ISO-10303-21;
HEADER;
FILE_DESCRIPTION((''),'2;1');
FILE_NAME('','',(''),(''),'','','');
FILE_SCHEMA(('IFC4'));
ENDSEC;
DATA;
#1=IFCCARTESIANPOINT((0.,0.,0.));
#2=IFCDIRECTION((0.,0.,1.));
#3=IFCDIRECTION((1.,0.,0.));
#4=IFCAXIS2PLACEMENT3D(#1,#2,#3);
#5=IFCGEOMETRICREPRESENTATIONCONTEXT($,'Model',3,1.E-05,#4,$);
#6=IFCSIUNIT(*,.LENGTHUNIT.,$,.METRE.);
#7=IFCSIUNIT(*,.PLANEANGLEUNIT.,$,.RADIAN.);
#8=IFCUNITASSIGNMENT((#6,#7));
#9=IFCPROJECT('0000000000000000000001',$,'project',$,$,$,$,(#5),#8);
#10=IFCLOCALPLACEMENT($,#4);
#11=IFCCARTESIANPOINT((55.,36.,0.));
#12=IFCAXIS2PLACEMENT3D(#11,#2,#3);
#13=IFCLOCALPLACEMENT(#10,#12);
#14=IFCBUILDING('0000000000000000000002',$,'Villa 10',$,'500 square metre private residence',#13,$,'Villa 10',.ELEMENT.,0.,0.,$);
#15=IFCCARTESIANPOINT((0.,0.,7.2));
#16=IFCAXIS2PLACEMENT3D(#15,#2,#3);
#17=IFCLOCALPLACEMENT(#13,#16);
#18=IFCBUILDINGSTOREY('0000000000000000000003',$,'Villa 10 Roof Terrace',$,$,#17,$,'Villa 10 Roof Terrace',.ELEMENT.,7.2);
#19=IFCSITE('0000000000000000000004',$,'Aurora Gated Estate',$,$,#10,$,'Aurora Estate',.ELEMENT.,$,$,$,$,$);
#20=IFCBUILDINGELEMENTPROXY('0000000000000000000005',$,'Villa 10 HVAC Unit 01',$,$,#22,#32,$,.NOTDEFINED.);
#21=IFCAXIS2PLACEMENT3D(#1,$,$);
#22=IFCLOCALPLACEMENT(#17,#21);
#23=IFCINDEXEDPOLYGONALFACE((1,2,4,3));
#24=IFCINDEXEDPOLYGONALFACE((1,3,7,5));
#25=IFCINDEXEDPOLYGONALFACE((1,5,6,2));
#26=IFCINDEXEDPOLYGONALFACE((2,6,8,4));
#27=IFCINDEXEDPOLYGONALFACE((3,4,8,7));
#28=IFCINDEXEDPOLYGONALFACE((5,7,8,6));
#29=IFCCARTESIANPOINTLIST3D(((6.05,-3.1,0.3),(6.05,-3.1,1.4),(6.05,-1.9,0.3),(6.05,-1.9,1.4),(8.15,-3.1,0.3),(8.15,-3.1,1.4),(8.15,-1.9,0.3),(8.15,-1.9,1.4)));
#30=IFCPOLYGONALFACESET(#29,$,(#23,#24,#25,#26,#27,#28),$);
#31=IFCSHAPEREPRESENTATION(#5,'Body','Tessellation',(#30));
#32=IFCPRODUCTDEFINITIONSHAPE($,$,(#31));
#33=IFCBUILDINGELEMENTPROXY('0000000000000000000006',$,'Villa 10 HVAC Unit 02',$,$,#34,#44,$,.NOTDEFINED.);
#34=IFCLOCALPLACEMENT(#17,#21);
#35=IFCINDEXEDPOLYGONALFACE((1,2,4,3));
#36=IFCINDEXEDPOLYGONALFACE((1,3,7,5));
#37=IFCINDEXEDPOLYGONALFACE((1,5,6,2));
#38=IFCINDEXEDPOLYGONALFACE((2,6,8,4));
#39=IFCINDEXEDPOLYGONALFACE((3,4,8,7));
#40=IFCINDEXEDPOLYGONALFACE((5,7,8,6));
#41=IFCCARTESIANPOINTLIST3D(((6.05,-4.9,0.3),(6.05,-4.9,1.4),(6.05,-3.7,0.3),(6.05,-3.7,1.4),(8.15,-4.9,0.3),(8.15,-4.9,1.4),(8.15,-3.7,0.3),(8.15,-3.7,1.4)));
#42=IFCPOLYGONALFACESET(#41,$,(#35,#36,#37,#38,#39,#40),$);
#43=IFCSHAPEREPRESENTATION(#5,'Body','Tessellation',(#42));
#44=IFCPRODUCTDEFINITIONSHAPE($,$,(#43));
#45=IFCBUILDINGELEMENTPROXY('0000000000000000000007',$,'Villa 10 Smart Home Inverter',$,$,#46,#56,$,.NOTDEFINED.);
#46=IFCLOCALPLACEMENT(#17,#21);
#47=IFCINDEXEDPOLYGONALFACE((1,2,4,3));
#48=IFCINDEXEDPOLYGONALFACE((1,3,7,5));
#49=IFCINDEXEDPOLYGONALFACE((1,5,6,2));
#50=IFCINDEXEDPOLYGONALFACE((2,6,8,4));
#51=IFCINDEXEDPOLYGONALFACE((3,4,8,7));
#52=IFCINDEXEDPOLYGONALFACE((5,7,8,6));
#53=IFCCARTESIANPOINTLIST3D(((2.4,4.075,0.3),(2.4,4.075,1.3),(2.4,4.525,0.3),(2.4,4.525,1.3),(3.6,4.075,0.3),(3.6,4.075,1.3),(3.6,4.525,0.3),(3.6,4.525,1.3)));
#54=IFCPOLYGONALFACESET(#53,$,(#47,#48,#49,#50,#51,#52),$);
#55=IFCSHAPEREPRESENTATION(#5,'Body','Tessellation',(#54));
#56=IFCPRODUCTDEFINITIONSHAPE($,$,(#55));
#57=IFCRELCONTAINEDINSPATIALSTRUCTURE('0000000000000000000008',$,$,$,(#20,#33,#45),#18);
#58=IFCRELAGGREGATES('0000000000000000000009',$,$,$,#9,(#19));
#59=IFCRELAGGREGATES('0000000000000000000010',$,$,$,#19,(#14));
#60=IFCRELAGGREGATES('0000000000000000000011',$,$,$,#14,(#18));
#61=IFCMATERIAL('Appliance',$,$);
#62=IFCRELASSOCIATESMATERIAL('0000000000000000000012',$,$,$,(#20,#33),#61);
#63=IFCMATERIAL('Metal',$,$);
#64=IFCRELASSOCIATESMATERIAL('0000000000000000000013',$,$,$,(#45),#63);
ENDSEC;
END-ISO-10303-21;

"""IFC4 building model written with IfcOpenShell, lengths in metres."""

from ifc_helpers import new_model, si_unit, frame, origin_with_axes, origin_2d_with_axis, place, context, project, spatial, rectangle, extrude, material, element, save


model = new_model("IFC4")

# Units and contexts
model_context = context("Model", 3, precision=1e-05, world=origin_with_axes())
ifc_project = project(units=[si_unit("LENGTHUNIT", "METRE"), si_unit("PLANEANGLEUNIT", "RADIAN")], contexts=[model_context])

# Site, building, storey
site_placement = place(None, origin_with_axes())
site = spatial("IfcSite", under=ifc_project, at=site_placement, Name="Aurora Gated Estate", LongName="Aurora Estate", CompositionType="ELEMENT")
building_placement = place(site_placement, frame((55.0, 36.0, 0.0), z_axis=(0.0, 0.0, 1.0), x_axis=(1.0, 0.0, 0.0)))
building = spatial("IfcBuilding", under=site, at=building_placement, Name="Villa 10", ObjectType="500 square metre private residence", LongName="Villa 10", CompositionType="ELEMENT", ElevationOfRefHeight=0.0, ElevationOfTerrain=0.0)
storey_placement = place(building_placement, frame((0.0, 0.0, 7.2), z_axis=(0.0, 0.0, 1.0), x_axis=(1.0, 0.0, 0.0)))
storey = spatial("IfcBuildingStorey", under=building, at=storey_placement, Name="Villa 10 Roof Terrace", LongName="Villa 10 Roof Terrace", CompositionType="ELEMENT", Elevation=7.2)

# Building element proxies
ifc_material_1 = material(Name="Metal")
ifc_material_2 = material(Name="Appliance")
for number, where, z_axis, x_axis, name in (
    (1, (7.1, -2.5, 0.3), (0.0, 0.0, 1.0), (1.0, 0.0, 0.0), "Villa 10 HVAC Unit 01"),
    (2, (7.1, -4.3, 0.3), (0.0, 0.0, 1.0), (1.0, 0.0, 0.0), "Villa 10 HVAC Unit 02"),
):
    element("IfcBuildingElementProxy", number, at=place(storey_placement, frame(where, z_axis=z_axis, x_axis=x_axis)), inside=storey, material=ifc_material_2, Name=name, PredefinedType="NOTDEFINED", context=model_context, shape_type="SweptSolid", body=[
        extrude(rectangle(XDim=2.1, YDim=1.2, at=origin_2d_with_axis()), origin_with_axes(), (0.0, 0.0, 1.0), 1.1),
    ])
proxy_1_placement = place(storey_placement, frame((3.0, 4.3, 0.3), z_axis=(0.0, 0.0, 1.0), x_axis=(1.0, 0.0, 0.0)))
element("IfcBuildingElementProxy", 3, at=proxy_1_placement, inside=storey, material=ifc_material_1, Name="Villa 10 Smart Home Inverter", PredefinedType="NOTDEFINED", context=model_context, shape_type="SweptSolid", body=[
    extrude(rectangle(XDim=1.2, YDim=0.45, at=origin_2d_with_axis()), origin_with_axes(), (0.0, 0.0, 1.0), 1.0),
])

save(model, "model.ifc")
